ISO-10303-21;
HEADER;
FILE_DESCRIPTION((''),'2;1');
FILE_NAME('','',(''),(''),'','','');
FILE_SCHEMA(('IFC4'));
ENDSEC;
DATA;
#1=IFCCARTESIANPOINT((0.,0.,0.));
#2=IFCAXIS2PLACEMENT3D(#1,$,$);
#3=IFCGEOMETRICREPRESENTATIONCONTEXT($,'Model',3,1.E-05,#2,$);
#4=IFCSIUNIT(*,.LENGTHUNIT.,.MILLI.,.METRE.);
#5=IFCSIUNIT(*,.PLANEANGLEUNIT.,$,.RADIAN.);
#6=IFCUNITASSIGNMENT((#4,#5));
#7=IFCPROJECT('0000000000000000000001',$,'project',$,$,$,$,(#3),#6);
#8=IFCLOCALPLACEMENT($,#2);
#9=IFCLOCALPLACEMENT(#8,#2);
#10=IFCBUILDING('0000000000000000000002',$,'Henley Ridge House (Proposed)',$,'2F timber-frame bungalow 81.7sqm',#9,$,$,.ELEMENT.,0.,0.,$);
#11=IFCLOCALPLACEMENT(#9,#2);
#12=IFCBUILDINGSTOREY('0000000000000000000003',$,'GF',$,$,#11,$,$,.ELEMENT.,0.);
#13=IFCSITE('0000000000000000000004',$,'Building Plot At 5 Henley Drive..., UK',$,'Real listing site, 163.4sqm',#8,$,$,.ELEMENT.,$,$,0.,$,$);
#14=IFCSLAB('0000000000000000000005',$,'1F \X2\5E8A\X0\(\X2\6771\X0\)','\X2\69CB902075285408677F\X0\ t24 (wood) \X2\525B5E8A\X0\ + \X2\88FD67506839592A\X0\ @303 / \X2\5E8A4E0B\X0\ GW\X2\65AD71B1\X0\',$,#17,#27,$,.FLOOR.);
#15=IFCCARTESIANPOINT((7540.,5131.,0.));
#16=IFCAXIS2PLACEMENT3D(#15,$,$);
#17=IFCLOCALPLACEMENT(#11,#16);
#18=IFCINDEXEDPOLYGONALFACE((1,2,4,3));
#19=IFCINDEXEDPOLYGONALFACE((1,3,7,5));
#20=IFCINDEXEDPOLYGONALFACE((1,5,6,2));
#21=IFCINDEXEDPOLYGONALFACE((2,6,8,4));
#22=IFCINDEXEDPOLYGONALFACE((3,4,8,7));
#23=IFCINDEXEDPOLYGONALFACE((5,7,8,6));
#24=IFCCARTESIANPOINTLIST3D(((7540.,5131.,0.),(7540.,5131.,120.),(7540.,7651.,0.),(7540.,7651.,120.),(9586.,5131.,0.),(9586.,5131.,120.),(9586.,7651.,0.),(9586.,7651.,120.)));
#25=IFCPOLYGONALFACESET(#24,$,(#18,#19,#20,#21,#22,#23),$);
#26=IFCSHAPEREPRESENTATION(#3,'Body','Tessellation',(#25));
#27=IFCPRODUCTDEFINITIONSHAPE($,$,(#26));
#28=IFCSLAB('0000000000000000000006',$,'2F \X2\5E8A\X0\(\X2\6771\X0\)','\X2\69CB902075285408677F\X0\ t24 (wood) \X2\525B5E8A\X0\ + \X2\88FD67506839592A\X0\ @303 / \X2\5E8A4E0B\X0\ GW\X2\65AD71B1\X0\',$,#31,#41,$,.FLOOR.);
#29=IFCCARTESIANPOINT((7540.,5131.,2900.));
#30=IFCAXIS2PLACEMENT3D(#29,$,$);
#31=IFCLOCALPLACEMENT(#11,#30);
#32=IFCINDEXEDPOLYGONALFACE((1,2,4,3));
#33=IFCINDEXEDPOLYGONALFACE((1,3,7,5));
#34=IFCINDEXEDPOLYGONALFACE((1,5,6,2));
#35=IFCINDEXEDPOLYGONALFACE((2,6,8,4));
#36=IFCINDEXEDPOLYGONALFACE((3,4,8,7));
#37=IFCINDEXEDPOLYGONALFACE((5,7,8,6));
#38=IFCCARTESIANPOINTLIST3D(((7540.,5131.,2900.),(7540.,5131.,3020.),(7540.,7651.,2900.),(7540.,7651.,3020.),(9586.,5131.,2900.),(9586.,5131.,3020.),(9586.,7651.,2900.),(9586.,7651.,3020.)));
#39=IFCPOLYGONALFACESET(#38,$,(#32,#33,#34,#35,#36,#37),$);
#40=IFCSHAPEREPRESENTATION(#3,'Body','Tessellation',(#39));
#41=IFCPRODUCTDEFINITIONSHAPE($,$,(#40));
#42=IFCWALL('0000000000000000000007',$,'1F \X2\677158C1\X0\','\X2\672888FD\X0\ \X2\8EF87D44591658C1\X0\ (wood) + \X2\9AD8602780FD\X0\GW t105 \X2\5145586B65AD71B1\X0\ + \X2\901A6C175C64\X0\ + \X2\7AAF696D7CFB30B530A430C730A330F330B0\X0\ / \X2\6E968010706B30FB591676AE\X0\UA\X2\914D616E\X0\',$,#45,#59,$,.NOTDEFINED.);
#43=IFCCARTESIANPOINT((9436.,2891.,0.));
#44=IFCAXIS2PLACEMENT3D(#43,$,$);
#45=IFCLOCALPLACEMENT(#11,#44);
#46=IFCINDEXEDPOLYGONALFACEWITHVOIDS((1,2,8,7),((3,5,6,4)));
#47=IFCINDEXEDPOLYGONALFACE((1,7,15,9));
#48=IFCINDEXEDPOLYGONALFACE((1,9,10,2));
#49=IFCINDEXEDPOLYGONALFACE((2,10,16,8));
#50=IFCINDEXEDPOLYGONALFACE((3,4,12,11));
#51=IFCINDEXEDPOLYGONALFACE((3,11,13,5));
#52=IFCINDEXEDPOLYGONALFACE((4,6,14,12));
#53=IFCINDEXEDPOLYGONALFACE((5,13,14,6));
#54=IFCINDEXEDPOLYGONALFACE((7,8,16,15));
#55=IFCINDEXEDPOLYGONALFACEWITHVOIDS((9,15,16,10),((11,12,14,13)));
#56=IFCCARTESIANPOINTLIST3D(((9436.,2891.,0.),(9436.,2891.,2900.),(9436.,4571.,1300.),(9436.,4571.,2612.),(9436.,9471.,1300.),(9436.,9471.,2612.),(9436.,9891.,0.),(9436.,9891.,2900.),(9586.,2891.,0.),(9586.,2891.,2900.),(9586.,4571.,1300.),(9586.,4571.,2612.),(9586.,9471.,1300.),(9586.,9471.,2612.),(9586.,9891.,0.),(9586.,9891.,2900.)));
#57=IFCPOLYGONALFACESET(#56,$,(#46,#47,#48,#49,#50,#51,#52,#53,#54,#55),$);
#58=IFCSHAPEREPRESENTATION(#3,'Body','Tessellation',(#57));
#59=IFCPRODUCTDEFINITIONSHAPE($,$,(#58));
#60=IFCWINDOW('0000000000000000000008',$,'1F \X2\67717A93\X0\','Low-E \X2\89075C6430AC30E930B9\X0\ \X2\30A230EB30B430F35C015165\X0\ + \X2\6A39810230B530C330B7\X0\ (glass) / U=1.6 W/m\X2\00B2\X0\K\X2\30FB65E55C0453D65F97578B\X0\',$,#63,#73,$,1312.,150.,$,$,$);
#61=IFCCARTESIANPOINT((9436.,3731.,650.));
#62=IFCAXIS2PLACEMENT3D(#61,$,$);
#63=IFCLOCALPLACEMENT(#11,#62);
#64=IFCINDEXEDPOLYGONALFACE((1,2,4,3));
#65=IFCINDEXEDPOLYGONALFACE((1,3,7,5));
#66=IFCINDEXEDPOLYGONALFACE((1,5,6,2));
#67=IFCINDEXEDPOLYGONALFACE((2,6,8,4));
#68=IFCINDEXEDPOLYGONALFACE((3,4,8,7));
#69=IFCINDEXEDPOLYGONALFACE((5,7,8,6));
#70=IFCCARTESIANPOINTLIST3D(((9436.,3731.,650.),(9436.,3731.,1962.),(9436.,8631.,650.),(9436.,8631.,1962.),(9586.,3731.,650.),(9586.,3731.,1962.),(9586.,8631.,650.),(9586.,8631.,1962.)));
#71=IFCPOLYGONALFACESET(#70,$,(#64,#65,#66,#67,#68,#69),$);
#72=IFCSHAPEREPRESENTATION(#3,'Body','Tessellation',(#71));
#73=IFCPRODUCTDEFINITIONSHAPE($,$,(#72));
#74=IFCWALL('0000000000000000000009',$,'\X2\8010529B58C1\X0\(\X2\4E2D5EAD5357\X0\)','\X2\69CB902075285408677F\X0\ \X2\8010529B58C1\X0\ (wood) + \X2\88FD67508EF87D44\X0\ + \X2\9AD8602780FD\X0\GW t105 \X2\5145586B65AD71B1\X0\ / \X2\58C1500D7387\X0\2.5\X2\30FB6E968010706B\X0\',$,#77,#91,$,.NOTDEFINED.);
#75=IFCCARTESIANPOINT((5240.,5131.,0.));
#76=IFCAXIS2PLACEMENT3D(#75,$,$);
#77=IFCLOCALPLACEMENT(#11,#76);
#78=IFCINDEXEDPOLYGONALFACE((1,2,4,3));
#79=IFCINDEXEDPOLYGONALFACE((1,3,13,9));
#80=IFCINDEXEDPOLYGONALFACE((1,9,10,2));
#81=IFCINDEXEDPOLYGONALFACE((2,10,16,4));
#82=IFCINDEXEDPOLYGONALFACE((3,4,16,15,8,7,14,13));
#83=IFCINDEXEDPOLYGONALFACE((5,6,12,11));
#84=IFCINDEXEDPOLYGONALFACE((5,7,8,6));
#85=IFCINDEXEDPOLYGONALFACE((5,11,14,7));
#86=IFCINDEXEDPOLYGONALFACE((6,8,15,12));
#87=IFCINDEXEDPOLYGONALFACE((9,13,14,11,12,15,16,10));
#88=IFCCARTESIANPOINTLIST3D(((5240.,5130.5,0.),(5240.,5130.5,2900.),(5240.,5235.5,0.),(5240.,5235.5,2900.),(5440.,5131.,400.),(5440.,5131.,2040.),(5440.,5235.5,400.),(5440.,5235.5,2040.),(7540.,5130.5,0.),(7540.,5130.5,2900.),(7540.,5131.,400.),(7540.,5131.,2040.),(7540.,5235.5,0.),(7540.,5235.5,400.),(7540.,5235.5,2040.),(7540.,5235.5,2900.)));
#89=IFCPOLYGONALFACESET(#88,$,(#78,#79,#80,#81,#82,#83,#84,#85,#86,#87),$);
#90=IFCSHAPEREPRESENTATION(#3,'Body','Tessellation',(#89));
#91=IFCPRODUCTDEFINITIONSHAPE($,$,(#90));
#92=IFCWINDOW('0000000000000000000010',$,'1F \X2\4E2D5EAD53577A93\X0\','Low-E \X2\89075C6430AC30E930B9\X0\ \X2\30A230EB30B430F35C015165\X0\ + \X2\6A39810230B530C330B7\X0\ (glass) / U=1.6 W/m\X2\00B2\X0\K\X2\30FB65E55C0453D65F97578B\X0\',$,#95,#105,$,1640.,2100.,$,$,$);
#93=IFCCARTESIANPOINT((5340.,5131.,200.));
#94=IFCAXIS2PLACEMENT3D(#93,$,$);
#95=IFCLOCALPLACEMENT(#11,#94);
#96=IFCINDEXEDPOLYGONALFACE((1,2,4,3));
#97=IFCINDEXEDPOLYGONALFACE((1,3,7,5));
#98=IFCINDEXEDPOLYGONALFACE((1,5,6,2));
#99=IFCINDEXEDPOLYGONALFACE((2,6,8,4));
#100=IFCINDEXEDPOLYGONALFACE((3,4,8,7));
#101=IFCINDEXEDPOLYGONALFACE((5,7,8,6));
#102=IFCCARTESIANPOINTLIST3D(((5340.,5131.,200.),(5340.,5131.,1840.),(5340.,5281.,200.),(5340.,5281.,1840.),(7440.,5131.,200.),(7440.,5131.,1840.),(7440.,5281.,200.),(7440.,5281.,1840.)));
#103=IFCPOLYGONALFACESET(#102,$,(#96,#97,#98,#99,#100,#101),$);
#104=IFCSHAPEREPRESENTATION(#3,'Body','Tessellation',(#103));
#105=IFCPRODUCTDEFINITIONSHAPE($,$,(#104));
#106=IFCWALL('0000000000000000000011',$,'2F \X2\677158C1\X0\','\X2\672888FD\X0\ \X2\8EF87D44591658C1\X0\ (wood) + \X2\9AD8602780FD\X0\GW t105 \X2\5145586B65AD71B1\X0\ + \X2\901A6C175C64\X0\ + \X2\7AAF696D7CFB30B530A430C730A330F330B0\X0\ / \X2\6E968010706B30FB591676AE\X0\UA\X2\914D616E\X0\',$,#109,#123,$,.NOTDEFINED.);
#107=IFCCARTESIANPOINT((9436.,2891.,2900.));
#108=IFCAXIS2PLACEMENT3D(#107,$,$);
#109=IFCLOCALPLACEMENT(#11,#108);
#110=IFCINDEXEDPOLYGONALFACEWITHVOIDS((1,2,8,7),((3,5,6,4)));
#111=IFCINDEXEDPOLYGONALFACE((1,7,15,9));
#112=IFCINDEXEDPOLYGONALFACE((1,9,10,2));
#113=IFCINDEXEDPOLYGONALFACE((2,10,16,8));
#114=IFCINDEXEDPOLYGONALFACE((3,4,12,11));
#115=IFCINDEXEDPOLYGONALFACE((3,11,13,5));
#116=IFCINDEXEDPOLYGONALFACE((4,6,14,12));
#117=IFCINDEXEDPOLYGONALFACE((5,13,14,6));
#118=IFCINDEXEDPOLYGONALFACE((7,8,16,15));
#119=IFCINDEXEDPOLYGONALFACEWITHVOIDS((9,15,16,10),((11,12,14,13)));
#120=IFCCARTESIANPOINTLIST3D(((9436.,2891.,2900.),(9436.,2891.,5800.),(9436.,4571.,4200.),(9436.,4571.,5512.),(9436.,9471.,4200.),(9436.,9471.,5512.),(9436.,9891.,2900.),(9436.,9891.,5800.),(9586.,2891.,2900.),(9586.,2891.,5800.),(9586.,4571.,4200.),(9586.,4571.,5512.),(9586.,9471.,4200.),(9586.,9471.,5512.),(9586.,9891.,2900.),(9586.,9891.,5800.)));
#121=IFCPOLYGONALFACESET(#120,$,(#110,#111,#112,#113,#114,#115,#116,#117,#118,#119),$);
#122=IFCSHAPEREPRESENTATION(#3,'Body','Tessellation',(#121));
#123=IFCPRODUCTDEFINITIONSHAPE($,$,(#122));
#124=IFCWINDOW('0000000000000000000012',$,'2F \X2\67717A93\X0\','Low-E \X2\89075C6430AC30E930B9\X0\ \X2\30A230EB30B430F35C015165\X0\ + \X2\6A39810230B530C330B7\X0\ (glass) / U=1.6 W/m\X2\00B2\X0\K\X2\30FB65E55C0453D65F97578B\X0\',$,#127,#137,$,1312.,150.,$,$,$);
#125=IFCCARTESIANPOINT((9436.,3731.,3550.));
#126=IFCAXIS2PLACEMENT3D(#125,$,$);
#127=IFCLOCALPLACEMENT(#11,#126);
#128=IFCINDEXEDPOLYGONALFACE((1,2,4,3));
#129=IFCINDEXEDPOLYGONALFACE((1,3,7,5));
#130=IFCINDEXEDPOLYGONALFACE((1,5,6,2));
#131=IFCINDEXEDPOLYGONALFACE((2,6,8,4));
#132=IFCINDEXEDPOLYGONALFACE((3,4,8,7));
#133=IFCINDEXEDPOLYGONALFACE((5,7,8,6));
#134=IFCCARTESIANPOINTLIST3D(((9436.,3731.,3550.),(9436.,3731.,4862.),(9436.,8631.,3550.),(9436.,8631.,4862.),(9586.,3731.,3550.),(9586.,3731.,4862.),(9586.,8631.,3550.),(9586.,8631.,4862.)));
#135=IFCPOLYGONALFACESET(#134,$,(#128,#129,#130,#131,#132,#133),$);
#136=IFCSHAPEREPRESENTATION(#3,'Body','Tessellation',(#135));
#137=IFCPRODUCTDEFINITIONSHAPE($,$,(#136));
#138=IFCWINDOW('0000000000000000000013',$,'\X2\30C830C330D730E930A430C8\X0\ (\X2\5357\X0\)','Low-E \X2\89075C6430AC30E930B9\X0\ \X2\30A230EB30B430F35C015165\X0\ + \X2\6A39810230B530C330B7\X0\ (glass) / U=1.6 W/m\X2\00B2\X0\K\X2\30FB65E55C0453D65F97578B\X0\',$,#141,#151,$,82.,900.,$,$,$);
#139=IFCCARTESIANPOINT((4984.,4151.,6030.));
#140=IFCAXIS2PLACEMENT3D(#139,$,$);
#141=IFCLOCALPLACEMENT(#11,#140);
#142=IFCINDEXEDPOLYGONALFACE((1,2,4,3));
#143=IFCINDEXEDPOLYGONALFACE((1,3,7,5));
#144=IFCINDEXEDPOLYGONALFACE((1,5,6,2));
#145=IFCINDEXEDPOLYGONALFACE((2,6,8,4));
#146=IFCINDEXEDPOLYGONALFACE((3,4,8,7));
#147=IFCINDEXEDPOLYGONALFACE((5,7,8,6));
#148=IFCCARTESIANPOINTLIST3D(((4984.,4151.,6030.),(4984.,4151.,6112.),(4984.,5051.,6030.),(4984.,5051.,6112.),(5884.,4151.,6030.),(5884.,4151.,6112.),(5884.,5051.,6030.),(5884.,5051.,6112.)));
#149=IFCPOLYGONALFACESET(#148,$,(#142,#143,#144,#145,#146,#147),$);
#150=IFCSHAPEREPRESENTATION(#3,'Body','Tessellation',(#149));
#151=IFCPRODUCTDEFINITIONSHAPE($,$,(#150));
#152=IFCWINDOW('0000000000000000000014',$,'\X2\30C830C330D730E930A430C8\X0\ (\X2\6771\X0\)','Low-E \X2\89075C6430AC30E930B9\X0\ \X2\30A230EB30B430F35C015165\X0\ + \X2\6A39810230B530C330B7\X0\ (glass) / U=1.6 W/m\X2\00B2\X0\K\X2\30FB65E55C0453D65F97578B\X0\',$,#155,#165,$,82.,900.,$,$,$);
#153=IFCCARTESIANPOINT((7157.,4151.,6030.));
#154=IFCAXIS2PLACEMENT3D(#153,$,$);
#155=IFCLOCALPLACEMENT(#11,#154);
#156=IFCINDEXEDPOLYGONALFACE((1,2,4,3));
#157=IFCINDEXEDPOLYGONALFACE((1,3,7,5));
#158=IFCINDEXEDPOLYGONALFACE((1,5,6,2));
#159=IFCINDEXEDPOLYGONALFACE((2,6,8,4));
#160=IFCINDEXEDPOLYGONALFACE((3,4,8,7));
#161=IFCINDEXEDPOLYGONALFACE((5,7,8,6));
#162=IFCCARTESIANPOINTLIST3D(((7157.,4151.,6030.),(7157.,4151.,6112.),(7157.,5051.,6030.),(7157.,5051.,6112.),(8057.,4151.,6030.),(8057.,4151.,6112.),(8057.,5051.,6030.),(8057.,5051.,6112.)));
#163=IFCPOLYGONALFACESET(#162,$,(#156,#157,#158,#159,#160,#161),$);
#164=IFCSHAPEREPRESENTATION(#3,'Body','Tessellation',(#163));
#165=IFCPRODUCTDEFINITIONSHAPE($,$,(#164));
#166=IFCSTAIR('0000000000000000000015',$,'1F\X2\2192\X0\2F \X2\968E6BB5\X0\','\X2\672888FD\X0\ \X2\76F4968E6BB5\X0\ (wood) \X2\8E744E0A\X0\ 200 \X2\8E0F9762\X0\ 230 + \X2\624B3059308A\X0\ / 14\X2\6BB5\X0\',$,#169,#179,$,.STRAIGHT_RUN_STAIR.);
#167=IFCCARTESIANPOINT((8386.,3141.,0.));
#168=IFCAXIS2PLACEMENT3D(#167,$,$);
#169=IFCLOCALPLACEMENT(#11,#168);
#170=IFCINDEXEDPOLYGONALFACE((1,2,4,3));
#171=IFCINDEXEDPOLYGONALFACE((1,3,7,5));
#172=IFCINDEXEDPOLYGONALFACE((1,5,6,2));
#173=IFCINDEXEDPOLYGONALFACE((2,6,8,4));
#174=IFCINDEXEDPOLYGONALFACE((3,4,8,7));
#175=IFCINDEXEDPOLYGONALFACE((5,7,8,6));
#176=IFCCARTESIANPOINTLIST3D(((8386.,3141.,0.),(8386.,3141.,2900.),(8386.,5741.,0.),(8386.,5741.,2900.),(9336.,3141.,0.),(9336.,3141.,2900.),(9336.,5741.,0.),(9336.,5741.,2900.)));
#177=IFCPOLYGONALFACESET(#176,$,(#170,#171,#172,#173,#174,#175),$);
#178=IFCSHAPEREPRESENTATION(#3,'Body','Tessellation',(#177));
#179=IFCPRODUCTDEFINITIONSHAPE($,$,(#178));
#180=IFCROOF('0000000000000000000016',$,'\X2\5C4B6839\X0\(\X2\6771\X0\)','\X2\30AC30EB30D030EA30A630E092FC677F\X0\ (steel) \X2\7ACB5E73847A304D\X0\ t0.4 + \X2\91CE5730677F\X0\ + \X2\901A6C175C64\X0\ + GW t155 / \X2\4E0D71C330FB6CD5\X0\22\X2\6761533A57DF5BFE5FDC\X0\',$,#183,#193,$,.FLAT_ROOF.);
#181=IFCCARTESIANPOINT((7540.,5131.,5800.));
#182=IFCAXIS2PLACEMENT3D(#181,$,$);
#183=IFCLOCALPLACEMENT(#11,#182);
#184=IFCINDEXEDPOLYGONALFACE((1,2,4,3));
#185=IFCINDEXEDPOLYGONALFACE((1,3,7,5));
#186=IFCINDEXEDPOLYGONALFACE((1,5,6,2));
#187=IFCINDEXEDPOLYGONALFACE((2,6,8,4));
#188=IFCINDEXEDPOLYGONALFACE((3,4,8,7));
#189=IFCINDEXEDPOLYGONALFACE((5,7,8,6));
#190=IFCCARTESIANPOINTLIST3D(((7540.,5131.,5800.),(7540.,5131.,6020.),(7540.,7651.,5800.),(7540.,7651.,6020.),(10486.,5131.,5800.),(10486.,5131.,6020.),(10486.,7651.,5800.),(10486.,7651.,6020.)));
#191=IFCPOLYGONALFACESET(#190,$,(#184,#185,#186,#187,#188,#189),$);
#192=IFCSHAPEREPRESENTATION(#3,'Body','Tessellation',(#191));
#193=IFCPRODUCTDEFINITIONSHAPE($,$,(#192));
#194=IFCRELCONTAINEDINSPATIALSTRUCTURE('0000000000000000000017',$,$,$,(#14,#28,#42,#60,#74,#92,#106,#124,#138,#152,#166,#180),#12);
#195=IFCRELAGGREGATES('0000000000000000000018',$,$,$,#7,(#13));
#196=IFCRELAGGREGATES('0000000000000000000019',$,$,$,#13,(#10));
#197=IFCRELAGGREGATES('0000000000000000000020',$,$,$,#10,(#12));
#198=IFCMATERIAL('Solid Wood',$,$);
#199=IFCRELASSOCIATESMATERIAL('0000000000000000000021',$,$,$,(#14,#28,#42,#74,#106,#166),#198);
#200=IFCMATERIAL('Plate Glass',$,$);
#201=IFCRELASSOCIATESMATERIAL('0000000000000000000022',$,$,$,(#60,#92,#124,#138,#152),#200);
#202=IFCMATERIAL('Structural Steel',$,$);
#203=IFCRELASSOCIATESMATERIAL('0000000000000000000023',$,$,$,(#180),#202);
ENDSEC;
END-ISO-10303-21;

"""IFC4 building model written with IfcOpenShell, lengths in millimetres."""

from ifc_helpers import new_model, si_unit, frame, frame_2d, origin, place, context, project, spatial, rectangle, extrude, material, element, fill, save


model = new_model("IFC4")

# Units and contexts
model_context = context("Model", 3, precision=1e-05, world=origin())
ifc_project = project(units=[si_unit("LENGTHUNIT", "METRE", prefix="MILLI"), si_unit("PLANEANGLEUNIT", "RADIAN")], contexts=[model_context])

# Site, building, storey
site_placement = place(None, origin())
site = spatial("IfcSite", under=ifc_project, at=site_placement, Name="Building Plot At 5 Henley Drive..., UK", ObjectType="Real listing site, 163.4sqm", CompositionType="ELEMENT", RefElevation=0.0)
building_placement = place(site_placement, origin())
building = spatial("IfcBuilding", under=site, at=building_placement, Name="Henley Ridge House (Proposed)", ObjectType="2F timber-frame bungalow 81.7sqm", CompositionType="ELEMENT", ElevationOfRefHeight=0.0, ElevationOfTerrain=0.0)
storey_placement = place(building_placement, origin())
storey = spatial("IfcBuildingStorey", under=building, at=storey_placement, Name="GF", CompositionType="ELEMENT", Elevation=0.0)

# Slabs
ifc_material_1 = material(Name="Solid Wood")
slab_1_placement = place(storey_placement, frame((7540.0, 5131.0, 0.0)))
element("IfcSlab", 1, at=slab_1_placement, inside=storey, material=ifc_material_1, Name="1F 床(東)", Description="構造用合板 t24 (wood) 剛床 + 製材根太 @303 / 床下 GW断熱", PredefinedType="FLOOR", context=model_context, shape_type="SweptSolid", body=[
    extrude(rectangle(XDim=2046.0, YDim=2520.0, at=frame_2d((1023.0, 1260.0))), frame((7540.0, 5131.0, 0.0)), (0.0, 0.0, 1.0), 120.0),
])
slab_2_placement = place(storey_placement, frame((7540.0, 5131.0, 2900.0)))
element("IfcSlab", 2, at=slab_2_placement, inside=storey, material=ifc_material_1, Name="2F 床(東)", Description="構造用合板 t24 (wood) 剛床 + 製材根太 @303 / 床下 GW断熱", PredefinedType="FLOOR", context=model_context, shape_type="SweptSolid", body=[
    extrude(rectangle(XDim=2046.0, YDim=2520.0, at=frame_2d((1023.0, 1260.0))), frame((7540.0, 5131.0, 2900.0)), (0.0, 0.0, 1.0), 120.0),
])

# Walls, openings, windows
wall_1_placement = place(storey_placement, frame((9436.0, 2891.0, 0.0)))
wall_1 = element("IfcWall", 3, at=wall_1_placement, inside=storey, material=ifc_material_1, Name="1F 東壁", Description="木製 軸組外壁 (wood) + 高性能GW t105 充填断熱 + 通気層 + 窯業系サイディング / 準耐火・外皮UA配慮", PredefinedType="NOTDEFINED", context=model_context, shape_type="SweptSolid", body=[
    extrude(rectangle(XDim=150.0, YDim=7000.0, at=frame_2d((75.0, 3500.0))), frame((9436.0, 2891.0, 0.0)), (0.0, 0.0, 1.0), 2900.0),
])
opening_1_placement = place(storey_placement, frame((9436.0, 3731.0, 650.0)))
opening_1 = element("IfcOpeningElement", 4, at=opening_1_placement, cuts=wall_1, PredefinedType="NOTDEFINED", context=model_context, shape_type="SweptSolid", body=[
    extrude(rectangle(XDim=150.0, YDim=4900.0, at=frame_2d((75.0, 2450.0))), frame((9436.0, 3731.0, 650.0)), (0.0, 0.0, 1.0), 1312.0),
])
ifc_material_2 = material(Name="Plate Glass")
window_1_placement = place(storey_placement, frame((9436.0, 3731.0, 650.0)))
window_1 = element("IfcWindow", 5, at=window_1_placement, inside=storey, material=ifc_material_2, Name="1F 東窓", Description="Low-E 複層ガラス アルゴン封入 + 樹脂サッシ (glass) / U=1.6 W/m²K・日射取得型", OverallHeight=1312.0, OverallWidth=150.0, context=model_context, shape_type="SweptSolid", body=[
    extrude(rectangle(XDim=150.0, YDim=4900.0, at=frame_2d((75.0, 2450.0))), frame((9436.0, 3731.0, 650.0)), (0.0, 0.0, 1.0), 1312.0),
])
fill(opening_1, window_1)
wall_2_placement = place(storey_placement, frame((5240.0, 5131.0, 0.0)))
wall_2 = element("IfcWall", 6, at=wall_2_placement, inside=storey, material=ifc_material_1, Name="耐力壁(中庭南)", Description="構造用合板 耐力壁 (wood) + 製材軸組 + 高性能GW t105 充填断熱 / 壁倍率2.5・準耐火", PredefinedType="NOTDEFINED", context=model_context, shape_type="SweptSolid", body=[
    extrude(rectangle(XDim=2300.0, YDim=105.0, at=frame_2d((1150.0, 52.0))), frame((5240.0, 5131.0, 0.0)), (0.0, 0.0, 1.0), 2900.0),
])
opening_2_placement = place(storey_placement, frame((5340.0, 5131.0, 200.0)))
opening_2 = element("IfcOpeningElement", 7, at=opening_2_placement, cuts=wall_2, PredefinedType="NOTDEFINED", context=model_context, shape_type="SweptSolid", body=[
    extrude(rectangle(XDim=2100.0, YDim=150.0, at=frame_2d((1050.0, 75.0))), frame((5340.0, 5131.0, 200.0)), (0.0, 0.0, 1.0), 1640.0),
])
window_2_placement = place(storey_placement, frame((5340.0, 5131.0, 200.0)))
window_2 = element("IfcWindow", 8, at=window_2_placement, inside=storey, material=ifc_material_2, Name="1F 中庭南窓", Description="Low-E 複層ガラス アルゴン封入 + 樹脂サッシ (glass) / U=1.6 W/m²K・日射取得型", OverallHeight=1640.0, OverallWidth=2100.0, context=model_context, shape_type="SweptSolid", body=[
    extrude(rectangle(XDim=2100.0, YDim=150.0, at=frame_2d((1050.0, 75.0))), frame((5340.0, 5131.0, 200.0)), (0.0, 0.0, 1.0), 1640.0),
])
fill(opening_2, window_2)

# Wall, opening, window
wall_3_placement = place(storey_placement, frame((9436.0, 2891.0, 2900.0)))
wall_3 = element("IfcWall", 9, at=wall_3_placement, inside=storey, material=ifc_material_1, Name="2F 東壁", Description="木製 軸組外壁 (wood) + 高性能GW t105 充填断熱 + 通気層 + 窯業系サイディング / 準耐火・外皮UA配慮", PredefinedType="NOTDEFINED", context=model_context, shape_type="SweptSolid", body=[
    extrude(rectangle(XDim=150.0, YDim=7000.0, at=frame_2d((75.0, 3500.0))), frame((9436.0, 2891.0, 2900.0)), (0.0, 0.0, 1.0), 2900.0),
])
opening_3_placement = place(storey_placement, frame((9436.0, 3731.0, 3550.0)))
opening_3 = element("IfcOpeningElement", 10, at=opening_3_placement, cuts=wall_3, PredefinedType="NOTDEFINED", context=model_context, shape_type="SweptSolid", body=[
    extrude(rectangle(XDim=150.0, YDim=4900.0, at=frame_2d((75.0, 2450.0))), frame((9436.0, 3731.0, 3550.0)), (0.0, 0.0, 1.0), 1312.0),
])
window_3_placement = place(storey_placement, frame((9436.0, 3731.0, 3550.0)))
window_3 = element("IfcWindow", 11, at=window_3_placement, inside=storey, material=ifc_material_2, Name="2F 東窓", Description="Low-E 複層ガラス アルゴン封入 + 樹脂サッシ (glass) / U=1.6 W/m²K・日射取得型", OverallHeight=1312.0, OverallWidth=150.0, context=model_context, shape_type="SweptSolid", body=[
    extrude(rectangle(XDim=150.0, YDim=4900.0, at=frame_2d((75.0, 2450.0))), frame((9436.0, 3731.0, 3550.0)), (0.0, 0.0, 1.0), 1312.0),
])
fill(opening_3, window_3)

# Windows
window_4_placement = place(storey_placement, frame((4984.0, 4151.0, 6030.0)))
element("IfcWindow", 12, at=window_4_placement, inside=storey, material=ifc_material_2, Name="トップライト (南)", Description="Low-E 複層ガラス アルゴン封入 + 樹脂サッシ (glass) / U=1.6 W/m²K・日射取得型", OverallHeight=82.0, OverallWidth=900.0, context=model_context, shape_type="SweptSolid", body=[
    extrude(rectangle(XDim=900.0, YDim=900.0, at=frame_2d((450.0, 450.0))), frame((4984.0, 4151.0, 6030.0)), (0.0, 0.0, 1.0), 82.0),
])
window_5_placement = place(storey_placement, frame((7157.0, 4151.0, 6030.0)))
element("IfcWindow", 13, at=window_5_placement, inside=storey, material=ifc_material_2, Name="トップライト (東)", Description="Low-E 複層ガラス アルゴン封入 + 樹脂サッシ (glass) / U=1.6 W/m²K・日射取得型", OverallHeight=82.0, OverallWidth=900.0, context=model_context, shape_type="SweptSolid", body=[
    extrude(rectangle(XDim=900.0, YDim=900.0, at=frame_2d((450.0, 450.0))), frame((7157.0, 4151.0, 6030.0)), (0.0, 0.0, 1.0), 82.0),
])

# Stair
stair_placement = place(storey_placement, frame((8386.0, 3141.0, 0.0)))
element("IfcStair", 14, at=stair_placement, inside=storey, material=ifc_material_1, Name="1F→2F 階段", Description="木製 直階段 (wood) 蹴上 200 踏面 230 + 手すり / 14段", PredefinedType="STRAIGHT_RUN_STAIR", context=model_context, shape_type="SweptSolid", body=[
    extrude(rectangle(XDim=950.0, YDim=2600.0, at=frame_2d((475.0, 1300.0))), frame((8386.0, 3141.0, 0.0)), (0.0, 0.0, 1.0), 2900.0),
])

# Roof
ifc_material_3 = material(Name="Structural Steel")
roof_placement = place(storey_placement, frame((7540.0, 5131.0, 5800.0)))
element("IfcRoof", 15, at=roof_placement, inside=storey, material=ifc_material_3, Name="屋根(東)", Description="ガルバリウム鋼板 (steel) 立平葺き t0.4 + 野地板 + 通気層 + GW t155 / 不燃・法22条区域対応", PredefinedType="FLAT_ROOF", context=model_context, shape_type="SweptSolid", body=[
    extrude(rectangle(XDim=2946.0, YDim=2520.0, at=frame_2d((1473.0, 1260.0))), frame((7540.0, 5131.0, 5800.0)), (0.0, 0.0, 1.0), 220.0),
])

save(model, "model.ifc")
